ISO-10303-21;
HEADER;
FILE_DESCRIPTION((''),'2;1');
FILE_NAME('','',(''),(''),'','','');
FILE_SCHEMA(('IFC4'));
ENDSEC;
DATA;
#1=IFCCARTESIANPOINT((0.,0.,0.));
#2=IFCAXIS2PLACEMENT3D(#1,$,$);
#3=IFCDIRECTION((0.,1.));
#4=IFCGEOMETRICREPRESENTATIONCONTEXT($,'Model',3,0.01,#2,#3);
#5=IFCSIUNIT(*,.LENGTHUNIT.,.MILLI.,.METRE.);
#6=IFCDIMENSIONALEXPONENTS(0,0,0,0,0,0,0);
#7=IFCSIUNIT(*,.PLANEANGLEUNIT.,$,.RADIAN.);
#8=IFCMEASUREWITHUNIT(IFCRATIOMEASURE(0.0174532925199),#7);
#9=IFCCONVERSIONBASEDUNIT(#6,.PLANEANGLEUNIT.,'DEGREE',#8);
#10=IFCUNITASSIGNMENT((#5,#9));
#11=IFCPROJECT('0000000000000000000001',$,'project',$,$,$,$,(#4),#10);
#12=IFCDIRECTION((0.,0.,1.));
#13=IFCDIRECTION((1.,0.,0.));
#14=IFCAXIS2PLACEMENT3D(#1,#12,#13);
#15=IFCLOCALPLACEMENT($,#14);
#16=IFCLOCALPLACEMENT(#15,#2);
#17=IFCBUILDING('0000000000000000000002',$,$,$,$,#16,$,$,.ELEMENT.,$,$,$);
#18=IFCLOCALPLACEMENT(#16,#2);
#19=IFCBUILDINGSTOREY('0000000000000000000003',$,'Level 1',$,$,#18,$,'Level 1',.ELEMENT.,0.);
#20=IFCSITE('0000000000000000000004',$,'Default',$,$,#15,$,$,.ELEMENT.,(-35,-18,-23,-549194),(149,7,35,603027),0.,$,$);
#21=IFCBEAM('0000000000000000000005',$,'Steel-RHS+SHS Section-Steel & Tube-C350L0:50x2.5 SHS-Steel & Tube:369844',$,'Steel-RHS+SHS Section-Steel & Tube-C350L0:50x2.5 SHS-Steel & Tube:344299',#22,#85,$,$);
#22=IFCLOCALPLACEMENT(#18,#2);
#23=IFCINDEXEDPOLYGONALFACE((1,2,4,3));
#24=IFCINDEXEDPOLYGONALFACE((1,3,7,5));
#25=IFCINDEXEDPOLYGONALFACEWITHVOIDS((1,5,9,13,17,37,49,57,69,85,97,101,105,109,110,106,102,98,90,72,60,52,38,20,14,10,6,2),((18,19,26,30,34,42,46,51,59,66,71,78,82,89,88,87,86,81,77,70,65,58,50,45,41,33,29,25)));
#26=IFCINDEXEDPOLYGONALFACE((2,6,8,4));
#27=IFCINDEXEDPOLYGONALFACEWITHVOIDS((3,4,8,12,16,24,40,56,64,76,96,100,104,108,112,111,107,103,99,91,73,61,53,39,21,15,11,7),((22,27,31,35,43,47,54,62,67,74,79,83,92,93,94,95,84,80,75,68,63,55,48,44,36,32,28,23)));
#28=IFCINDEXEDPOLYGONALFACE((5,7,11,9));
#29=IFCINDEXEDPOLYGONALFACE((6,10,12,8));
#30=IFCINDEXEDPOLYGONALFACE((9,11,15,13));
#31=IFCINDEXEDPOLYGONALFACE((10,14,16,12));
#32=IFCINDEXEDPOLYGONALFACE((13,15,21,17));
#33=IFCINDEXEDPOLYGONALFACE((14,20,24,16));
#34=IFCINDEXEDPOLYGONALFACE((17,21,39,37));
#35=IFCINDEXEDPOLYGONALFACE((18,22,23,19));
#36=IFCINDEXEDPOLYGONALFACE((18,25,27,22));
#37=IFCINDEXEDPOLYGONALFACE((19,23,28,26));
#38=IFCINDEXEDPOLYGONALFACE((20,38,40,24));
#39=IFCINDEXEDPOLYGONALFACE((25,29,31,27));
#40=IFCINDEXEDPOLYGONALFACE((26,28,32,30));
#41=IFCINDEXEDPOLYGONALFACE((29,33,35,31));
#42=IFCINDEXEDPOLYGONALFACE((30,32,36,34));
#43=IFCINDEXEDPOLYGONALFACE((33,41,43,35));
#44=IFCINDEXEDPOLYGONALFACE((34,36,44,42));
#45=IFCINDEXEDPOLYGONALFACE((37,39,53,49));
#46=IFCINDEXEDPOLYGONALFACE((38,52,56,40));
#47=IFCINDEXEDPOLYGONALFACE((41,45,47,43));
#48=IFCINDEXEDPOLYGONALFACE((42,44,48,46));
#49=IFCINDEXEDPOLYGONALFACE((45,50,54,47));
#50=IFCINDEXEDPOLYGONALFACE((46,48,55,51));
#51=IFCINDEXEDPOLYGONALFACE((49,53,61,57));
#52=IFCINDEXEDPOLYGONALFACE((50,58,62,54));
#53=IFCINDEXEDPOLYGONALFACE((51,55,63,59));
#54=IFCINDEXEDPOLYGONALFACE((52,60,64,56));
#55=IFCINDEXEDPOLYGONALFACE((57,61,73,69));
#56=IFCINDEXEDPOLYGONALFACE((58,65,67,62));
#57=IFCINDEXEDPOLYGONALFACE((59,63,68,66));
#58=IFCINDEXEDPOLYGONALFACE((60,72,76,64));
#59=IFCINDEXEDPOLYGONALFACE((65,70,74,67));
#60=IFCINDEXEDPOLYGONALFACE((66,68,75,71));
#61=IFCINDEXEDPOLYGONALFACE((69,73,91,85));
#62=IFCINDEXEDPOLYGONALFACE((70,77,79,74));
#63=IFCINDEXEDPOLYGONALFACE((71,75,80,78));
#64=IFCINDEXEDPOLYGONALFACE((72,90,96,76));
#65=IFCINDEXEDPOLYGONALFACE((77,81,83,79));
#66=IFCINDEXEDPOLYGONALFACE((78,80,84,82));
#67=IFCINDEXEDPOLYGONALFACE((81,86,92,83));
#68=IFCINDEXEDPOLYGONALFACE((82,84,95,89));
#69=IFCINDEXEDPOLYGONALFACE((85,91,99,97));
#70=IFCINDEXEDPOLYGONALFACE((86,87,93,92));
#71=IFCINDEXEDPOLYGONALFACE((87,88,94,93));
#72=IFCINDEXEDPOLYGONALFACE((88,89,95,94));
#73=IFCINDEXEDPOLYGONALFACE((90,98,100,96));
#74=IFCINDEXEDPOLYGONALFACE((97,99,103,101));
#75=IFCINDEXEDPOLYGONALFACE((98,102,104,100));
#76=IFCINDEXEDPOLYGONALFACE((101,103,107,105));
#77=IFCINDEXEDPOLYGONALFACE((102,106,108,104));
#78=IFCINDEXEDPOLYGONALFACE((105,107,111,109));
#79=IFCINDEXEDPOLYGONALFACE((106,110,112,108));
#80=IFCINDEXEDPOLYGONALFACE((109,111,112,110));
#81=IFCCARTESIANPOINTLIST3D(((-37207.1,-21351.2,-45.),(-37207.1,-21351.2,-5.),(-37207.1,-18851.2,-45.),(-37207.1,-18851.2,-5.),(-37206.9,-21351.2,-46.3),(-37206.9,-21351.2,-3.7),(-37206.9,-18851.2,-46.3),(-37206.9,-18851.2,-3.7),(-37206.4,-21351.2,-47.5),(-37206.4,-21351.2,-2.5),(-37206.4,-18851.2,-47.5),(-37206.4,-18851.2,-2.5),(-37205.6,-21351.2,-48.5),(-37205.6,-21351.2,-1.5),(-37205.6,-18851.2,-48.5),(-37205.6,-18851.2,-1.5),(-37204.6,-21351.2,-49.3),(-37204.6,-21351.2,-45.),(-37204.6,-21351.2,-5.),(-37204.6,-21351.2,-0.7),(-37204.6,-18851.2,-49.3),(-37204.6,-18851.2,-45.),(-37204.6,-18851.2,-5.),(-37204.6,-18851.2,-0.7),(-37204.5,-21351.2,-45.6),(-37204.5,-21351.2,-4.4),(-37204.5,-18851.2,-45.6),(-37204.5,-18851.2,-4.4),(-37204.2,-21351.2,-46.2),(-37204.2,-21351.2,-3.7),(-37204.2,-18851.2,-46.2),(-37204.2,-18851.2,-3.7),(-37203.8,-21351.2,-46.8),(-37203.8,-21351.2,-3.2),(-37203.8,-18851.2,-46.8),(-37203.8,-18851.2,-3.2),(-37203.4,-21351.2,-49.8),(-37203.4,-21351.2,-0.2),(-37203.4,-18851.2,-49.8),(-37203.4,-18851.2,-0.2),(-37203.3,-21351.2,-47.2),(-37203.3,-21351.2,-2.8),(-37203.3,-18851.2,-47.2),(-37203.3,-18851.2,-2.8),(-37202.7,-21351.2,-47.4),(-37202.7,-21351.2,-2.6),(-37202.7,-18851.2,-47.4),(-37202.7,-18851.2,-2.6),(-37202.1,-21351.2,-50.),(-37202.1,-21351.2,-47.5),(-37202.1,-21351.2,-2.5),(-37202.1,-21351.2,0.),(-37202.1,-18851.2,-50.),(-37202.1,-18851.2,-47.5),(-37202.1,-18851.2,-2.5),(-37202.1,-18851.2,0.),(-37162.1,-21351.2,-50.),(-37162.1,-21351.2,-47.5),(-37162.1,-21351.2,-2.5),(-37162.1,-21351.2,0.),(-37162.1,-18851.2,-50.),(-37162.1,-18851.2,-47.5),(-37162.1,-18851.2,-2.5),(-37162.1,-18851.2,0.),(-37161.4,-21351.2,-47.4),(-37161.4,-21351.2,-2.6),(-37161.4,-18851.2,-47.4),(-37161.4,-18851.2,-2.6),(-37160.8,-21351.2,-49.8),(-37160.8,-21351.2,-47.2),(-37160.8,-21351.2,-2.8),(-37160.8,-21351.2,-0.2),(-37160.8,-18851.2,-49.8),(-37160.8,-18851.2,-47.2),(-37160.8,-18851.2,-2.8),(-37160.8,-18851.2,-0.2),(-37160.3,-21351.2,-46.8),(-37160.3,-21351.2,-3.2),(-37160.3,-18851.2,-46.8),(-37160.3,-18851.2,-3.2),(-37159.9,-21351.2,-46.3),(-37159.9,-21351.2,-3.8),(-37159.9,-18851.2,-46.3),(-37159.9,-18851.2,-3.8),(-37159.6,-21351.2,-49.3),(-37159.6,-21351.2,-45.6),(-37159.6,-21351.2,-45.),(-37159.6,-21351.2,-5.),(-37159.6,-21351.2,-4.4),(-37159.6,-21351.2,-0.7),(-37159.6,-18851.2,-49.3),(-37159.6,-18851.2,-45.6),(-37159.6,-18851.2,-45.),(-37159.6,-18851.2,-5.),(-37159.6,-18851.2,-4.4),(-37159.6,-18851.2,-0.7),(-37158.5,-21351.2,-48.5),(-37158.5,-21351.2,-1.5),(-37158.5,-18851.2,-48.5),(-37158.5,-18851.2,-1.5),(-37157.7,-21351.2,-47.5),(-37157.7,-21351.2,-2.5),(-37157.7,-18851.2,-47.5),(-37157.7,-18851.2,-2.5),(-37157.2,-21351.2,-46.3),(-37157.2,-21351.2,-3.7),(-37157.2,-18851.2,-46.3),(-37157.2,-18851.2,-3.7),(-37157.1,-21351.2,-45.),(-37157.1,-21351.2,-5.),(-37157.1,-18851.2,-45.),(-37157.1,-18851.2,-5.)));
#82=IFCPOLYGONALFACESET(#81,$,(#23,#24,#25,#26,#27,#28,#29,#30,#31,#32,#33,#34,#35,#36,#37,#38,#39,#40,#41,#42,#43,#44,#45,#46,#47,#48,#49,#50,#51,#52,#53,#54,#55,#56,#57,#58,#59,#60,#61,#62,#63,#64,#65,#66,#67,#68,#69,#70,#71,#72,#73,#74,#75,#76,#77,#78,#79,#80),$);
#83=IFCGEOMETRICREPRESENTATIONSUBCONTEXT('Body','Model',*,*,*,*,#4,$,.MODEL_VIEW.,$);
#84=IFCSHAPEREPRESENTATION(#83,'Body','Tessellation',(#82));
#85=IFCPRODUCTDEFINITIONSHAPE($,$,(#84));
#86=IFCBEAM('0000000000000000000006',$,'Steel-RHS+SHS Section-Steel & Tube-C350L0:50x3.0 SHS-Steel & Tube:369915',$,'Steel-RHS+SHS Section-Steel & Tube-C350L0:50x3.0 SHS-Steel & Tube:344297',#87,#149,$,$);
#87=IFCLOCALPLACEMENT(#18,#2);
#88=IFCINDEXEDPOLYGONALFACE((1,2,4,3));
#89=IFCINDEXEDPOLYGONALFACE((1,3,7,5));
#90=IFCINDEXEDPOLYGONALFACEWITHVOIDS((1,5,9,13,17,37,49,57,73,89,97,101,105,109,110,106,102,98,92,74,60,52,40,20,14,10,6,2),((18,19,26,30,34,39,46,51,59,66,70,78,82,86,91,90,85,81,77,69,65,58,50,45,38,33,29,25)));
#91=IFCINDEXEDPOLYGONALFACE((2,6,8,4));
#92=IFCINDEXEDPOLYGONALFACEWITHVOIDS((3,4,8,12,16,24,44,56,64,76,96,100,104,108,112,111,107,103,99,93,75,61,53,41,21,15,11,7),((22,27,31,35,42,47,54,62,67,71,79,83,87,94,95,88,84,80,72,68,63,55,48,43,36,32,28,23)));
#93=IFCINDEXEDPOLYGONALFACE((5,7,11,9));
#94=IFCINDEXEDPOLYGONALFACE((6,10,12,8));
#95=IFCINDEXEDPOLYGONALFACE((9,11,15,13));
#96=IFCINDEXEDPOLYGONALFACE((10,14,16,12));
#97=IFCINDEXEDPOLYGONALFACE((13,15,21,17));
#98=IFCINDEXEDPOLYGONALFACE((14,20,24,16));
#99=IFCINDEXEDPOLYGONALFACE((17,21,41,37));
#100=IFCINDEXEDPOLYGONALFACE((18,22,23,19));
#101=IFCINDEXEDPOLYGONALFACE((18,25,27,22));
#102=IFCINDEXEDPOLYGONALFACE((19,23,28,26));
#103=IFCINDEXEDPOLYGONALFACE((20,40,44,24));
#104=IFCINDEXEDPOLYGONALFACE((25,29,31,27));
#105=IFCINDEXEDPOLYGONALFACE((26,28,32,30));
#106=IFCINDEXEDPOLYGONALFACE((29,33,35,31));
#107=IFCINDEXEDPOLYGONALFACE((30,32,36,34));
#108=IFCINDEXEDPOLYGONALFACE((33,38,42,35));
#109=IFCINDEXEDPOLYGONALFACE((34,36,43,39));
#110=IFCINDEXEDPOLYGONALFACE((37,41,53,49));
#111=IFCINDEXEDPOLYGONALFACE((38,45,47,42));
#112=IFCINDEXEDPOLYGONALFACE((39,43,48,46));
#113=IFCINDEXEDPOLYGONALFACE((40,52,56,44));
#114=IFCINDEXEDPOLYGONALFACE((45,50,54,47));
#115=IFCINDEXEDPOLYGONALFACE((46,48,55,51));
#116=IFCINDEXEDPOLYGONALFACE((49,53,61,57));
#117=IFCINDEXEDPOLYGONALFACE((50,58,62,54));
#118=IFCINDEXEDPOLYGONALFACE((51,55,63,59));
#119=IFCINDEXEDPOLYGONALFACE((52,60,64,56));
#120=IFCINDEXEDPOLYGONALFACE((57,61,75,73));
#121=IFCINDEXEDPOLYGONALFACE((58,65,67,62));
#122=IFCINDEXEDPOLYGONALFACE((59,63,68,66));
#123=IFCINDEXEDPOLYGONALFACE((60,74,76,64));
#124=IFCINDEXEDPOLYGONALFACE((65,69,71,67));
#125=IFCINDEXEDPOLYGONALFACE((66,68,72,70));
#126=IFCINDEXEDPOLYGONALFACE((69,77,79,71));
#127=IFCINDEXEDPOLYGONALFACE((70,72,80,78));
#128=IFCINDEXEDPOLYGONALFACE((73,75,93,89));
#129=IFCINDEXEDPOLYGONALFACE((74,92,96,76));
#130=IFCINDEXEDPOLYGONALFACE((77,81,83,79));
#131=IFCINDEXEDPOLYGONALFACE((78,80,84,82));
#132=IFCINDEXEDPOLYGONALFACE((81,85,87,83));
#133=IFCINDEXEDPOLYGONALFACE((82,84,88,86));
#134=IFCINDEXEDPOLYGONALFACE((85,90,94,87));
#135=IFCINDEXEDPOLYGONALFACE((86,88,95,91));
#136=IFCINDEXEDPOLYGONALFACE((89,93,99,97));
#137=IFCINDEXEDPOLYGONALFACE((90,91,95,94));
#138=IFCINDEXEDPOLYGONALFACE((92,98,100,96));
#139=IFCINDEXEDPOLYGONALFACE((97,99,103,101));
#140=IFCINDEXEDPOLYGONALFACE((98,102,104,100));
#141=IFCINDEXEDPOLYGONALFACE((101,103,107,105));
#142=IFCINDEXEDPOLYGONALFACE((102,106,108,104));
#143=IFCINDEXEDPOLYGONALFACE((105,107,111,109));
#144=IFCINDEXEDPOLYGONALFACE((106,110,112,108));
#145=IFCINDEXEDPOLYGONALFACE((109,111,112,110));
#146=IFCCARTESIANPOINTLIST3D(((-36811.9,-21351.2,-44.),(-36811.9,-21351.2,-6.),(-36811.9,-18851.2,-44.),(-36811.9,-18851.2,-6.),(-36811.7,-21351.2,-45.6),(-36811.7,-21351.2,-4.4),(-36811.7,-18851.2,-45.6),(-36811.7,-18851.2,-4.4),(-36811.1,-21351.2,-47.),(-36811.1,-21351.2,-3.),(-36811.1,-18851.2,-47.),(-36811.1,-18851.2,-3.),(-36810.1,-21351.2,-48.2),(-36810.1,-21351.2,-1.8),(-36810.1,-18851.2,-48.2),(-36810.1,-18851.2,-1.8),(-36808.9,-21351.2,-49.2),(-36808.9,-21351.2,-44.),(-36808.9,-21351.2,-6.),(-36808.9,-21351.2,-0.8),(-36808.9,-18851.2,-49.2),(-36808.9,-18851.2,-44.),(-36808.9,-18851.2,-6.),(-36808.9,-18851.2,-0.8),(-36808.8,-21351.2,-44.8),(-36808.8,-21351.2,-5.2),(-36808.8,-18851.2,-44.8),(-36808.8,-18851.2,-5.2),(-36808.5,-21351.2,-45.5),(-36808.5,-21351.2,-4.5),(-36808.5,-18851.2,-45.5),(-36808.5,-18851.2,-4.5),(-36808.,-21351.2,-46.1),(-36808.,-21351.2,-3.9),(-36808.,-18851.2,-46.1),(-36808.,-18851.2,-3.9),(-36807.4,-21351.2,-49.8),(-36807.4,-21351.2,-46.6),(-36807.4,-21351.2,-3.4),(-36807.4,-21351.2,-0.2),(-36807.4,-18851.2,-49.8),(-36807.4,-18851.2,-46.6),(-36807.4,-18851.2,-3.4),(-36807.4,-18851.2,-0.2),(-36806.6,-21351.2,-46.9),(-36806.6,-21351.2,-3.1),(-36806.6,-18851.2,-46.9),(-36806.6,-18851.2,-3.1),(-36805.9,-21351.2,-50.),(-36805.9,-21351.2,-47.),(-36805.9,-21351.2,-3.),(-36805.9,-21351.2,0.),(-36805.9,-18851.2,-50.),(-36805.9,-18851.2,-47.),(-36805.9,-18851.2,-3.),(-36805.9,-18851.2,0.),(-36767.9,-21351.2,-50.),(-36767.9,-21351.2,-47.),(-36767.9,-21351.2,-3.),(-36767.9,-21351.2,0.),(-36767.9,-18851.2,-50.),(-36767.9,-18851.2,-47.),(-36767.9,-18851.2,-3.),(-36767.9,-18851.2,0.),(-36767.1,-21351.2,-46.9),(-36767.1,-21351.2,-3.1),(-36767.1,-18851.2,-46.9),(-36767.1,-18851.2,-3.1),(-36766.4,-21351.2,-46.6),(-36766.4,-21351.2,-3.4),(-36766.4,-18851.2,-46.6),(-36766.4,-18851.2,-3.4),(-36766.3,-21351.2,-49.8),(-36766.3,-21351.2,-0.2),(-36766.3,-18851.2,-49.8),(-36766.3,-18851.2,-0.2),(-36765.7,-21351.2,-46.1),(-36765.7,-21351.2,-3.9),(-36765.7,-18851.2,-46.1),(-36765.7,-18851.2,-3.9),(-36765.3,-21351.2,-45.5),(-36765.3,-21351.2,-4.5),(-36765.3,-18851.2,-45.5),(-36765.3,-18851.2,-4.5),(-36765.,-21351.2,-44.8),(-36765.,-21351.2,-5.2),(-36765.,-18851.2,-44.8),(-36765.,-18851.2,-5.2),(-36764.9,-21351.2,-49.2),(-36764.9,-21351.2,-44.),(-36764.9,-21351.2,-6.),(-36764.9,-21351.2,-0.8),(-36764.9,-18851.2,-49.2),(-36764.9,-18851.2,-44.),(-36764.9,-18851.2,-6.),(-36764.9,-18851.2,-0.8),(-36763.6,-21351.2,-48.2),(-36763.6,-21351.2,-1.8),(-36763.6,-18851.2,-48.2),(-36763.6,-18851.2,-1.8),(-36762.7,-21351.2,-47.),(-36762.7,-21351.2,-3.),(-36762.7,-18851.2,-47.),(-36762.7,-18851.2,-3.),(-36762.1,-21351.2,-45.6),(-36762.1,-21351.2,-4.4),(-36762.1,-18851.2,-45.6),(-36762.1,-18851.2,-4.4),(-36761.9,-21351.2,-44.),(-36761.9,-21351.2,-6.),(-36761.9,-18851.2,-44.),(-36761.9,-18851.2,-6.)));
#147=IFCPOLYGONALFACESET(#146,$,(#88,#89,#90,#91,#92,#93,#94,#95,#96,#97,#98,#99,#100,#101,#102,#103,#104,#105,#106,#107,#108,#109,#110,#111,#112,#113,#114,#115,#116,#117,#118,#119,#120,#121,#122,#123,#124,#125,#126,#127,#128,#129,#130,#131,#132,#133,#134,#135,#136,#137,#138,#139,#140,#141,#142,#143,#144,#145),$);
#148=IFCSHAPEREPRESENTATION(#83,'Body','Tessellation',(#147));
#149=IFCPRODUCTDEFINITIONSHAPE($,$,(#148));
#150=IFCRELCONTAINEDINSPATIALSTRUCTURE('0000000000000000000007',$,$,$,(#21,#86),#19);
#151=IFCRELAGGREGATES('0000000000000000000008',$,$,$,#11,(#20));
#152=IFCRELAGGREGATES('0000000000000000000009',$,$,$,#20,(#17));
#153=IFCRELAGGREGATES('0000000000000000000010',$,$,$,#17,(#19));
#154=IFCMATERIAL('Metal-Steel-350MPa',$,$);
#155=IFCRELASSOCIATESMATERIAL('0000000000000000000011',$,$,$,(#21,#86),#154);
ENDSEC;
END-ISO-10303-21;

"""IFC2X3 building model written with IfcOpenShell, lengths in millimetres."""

from ifc_helpers import new_model, entity, si_unit, converted_unit, direction, frame, frame_2d, origin, origin_with_axes, place, context, subcontext, project, spatial, polyline, circle_curve, parameter, trimmed, segment, composite_curve, outline, extrude, material, element, save


model = new_model("IFC2X3")

# Units and contexts
model_context = context("Model", 3, precision=0.01, world=origin(), true_north=direction((0.0, 1.0)))
body_context = subcontext(model_context, "Body", "Model", "MODEL_VIEW")
ifc_project = project(units=[si_unit("LENGTHUNIT", "METRE", prefix="MILLI"), converted_unit("PLANEANGLEUNIT", "DEGREE", entity("IfcRatioMeasure", 0.0174532925199), si_unit("PLANEANGLEUNIT", "RADIAN"), dimensions=[0, 0, 0, 0, 0, 0, 0])], contexts=[model_context])

# Site, building, storey
site_placement = place(None, origin_with_axes())
site = spatial("IfcSite", under=ifc_project, at=site_placement, Name="Default", CompositionType="ELEMENT", RefLatitude=(-35, -18, -23, -549194), RefLongitude=(149, 7, 35, 603027), RefElevation=0.0)
building_placement = place(site_placement, origin())
building = spatial("IfcBuilding", under=site, at=building_placement, CompositionType="ELEMENT")
storey_placement = place(building_placement, origin())
storey = spatial("IfcBuildingStorey", under=building, at=storey_placement, Name="Level 1", LongName="Level 1", CompositionType="ELEMENT", Elevation=0.0)

# Beams
ifc_material = material(Name="Metal-Steel-350MPa")
beam_1_placement = place(storey_placement, frame((-37182.1, -18851.2, 0.0), z_axis=(0.0, 0.0, 1.0), x_axis=(0.0, -1.0, 0.0)))
element("IfcBeam", 1, at=beam_1_placement, inside=storey, material=ifc_material, Name="Steel-RHS+SHS Section-Steel & Tube-C350L0:50x2.5 SHS-Steel & Tube:369844", ObjectType="Steel-RHS+SHS Section-Steel & Tube-C350L0:50x2.5 SHS-Steel & Tube:344299", context=body_context, shape_type="SweptSolid", body=[
    extrude(outline(composite_curve([segment(trimmed(circle_curve(frame_2d((-20.0, -20.0), x_axis=(1.0, 0.0)), 5.0), [parameter(180.0)], [parameter(270.0)], True, "PARAMETER"), True, "CONTINUOUS"), segment(polyline([(-20.0, -25.0), (20.0, -25.0)]), True, "CONTINUOUS"), segment(trimmed(circle_curve(frame_2d((20.0, -20.0), x_axis=(1.0, 0.0)), 5.0), [parameter(270.0)], [parameter(0.0)], True, "PARAMETER"), True, "CONTINUOUS"), segment(polyline([(25.0, -20.0), (25.0, 20.0)]), True, "CONTINUOUS"), segment(trimmed(circle_curve(frame_2d((20.0, 20.0), x_axis=(1.0, 0.0)), 5.0), [parameter(0.0)], [parameter(90.0)], True, "PARAMETER"), True, "CONTINUOUS"), segment(polyline([(20.0, 25.0), (-20.0, 25.0)]), True, "CONTINUOUS"), segment(trimmed(circle_curve(frame_2d((-20.0, 20.0), x_axis=(1.0, 0.0)), 5.0), [parameter(90.0)], [parameter(180.0)], True, "PARAMETER"), True, "CONTINUOUS"), segment(polyline([(-25.0, 20.0), (-25.0, -20.0)]), True, "CONTINUOUS")], self_intersect=False), holes=[composite_curve([segment(polyline([(20.0, -22.5), (-20.0, -22.5)]), True, "CONTINUOUS"), segment(trimmed(circle_curve(frame_2d((-20.0, -20.0), x_axis=(1.0, 0.0)), 2.5), [parameter(180.0)], [parameter(270.0)], True, "PARAMETER"), False, "CONTINUOUS"), segment(polyline([(-22.5, -20.0), (-22.5, 20.0)]), True, "CONTINUOUS"), segment(trimmed(circle_curve(frame_2d((-20.0, 20.0), x_axis=(1.0, 0.0)), 2.5), [parameter(90.0)], [parameter(180.0)], True, "PARAMETER"), False, "CONTINUOUS"), segment(polyline([(-20.0, 22.5), (20.0, 22.5)]), True, "CONTINUOUS"), segment(trimmed(circle_curve(frame_2d((20.0, 20.0), x_axis=(1.0, 0.0)), 2.5), [parameter(360.0)], [parameter(90.0)], True, "PARAMETER"), False, "CONTINUOUS"), segment(polyline([(22.5, 20.0), (22.5, -20.0)]), True, "CONTINUOUS"), segment(trimmed(circle_curve(frame_2d((20.0, -20.0), x_axis=(1.0, 0.0)), 2.5), [parameter(270.0)], [parameter(0.0)], True, "PARAMETER"), False, "CONTINUOUS")], self_intersect=False)]), frame((0.0, 0.0, -25.0), z_axis=(1.0, 0.0, 0.0), x_axis=(0.0, -1.0, 0.0)), (0.0, 0.0, 1.0), 2500.0),
])
beam_2_placement = place(storey_placement, frame((-36786.9, -18851.2, 0.0), z_axis=(0.0, 0.0, 1.0), x_axis=(0.0, -1.0, 0.0)))
element("IfcBeam", 2, at=beam_2_placement, inside=storey, material=ifc_material, Name="Steel-RHS+SHS Section-Steel & Tube-C350L0:50x3.0 SHS-Steel & Tube:369915", ObjectType="Steel-RHS+SHS Section-Steel & Tube-C350L0:50x3.0 SHS-Steel & Tube:344297", context=body_context, shape_type="SweptSolid", body=[
    extrude(outline(composite_curve([segment(trimmed(circle_curve(frame_2d((-19.0, -19.0), x_axis=(1.0, 0.0)), 6.0), [parameter(180.0)], [parameter(270.0)], True, "PARAMETER"), True, "CONTINUOUS"), segment(polyline([(-19.0, -25.0), (19.0, -25.0)]), True, "CONTINUOUS"), segment(trimmed(circle_curve(frame_2d((19.0, -19.0), x_axis=(1.0, 0.0)), 6.0), [parameter(270.0)], [parameter(0.0)], True, "PARAMETER"), True, "CONTINUOUS"), segment(polyline([(25.0, -19.0), (25.0, 19.0)]), True, "CONTINUOUS"), segment(trimmed(circle_curve(frame_2d((19.0, 19.0), x_axis=(1.0, 0.0)), 6.0), [parameter(0.0)], [parameter(90.0)], True, "PARAMETER"), True, "CONTINUOUS"), segment(polyline([(19.0, 25.0), (-19.0, 25.0)]), True, "CONTINUOUS"), segment(trimmed(circle_curve(frame_2d((-19.0, 19.0), x_axis=(1.0, 0.0)), 6.0), [parameter(90.0)], [parameter(180.0)], True, "PARAMETER"), True, "CONTINUOUS"), segment(polyline([(-25.0, 19.0), (-25.0, -19.0)]), True, "CONTINUOUS")], self_intersect=False), holes=[composite_curve([segment(polyline([(19.0, -22.0), (-19.0, -22.0)]), True, "CONTINUOUS"), segment(trimmed(circle_curve(frame_2d((-19.0, -19.0), x_axis=(1.0, 0.0)), 3.0), [parameter(180.0)], [parameter(270.0)], True, "PARAMETER"), False, "CONTINUOUS"), segment(polyline([(-22.0, -19.0), (-22.0, 19.0)]), True, "CONTINUOUS"), segment(trimmed(circle_curve(frame_2d((-19.0, 19.0), x_axis=(1.0, 0.0)), 3.0), [parameter(90.0)], [parameter(180.0)], True, "PARAMETER"), False, "CONTINUOUS"), segment(polyline([(-19.0, 22.0), (19.0, 22.0)]), True, "CONTINUOUS"), segment(trimmed(circle_curve(frame_2d((19.0, 19.0), x_axis=(1.0, 0.0)), 3.0), [parameter(360.0)], [parameter(90.0)], True, "PARAMETER"), False, "CONTINUOUS"), segment(polyline([(22.0, 19.0), (22.0, -19.0)]), True, "CONTINUOUS"), segment(trimmed(circle_curve(frame_2d((19.0, -19.0), x_axis=(1.0, 0.0)), 3.0), [parameter(270.0)], [parameter(0.0)], True, "PARAMETER"), False, "CONTINUOUS")], self_intersect=False)]), frame((0.0, 0.0, -25.0), z_axis=(1.0, 0.0, 0.0), x_axis=(0.0, -1.0, 0.0)), (0.0, 0.0, 1.0), 2500.0),
])

save(model, "model.ifc")
